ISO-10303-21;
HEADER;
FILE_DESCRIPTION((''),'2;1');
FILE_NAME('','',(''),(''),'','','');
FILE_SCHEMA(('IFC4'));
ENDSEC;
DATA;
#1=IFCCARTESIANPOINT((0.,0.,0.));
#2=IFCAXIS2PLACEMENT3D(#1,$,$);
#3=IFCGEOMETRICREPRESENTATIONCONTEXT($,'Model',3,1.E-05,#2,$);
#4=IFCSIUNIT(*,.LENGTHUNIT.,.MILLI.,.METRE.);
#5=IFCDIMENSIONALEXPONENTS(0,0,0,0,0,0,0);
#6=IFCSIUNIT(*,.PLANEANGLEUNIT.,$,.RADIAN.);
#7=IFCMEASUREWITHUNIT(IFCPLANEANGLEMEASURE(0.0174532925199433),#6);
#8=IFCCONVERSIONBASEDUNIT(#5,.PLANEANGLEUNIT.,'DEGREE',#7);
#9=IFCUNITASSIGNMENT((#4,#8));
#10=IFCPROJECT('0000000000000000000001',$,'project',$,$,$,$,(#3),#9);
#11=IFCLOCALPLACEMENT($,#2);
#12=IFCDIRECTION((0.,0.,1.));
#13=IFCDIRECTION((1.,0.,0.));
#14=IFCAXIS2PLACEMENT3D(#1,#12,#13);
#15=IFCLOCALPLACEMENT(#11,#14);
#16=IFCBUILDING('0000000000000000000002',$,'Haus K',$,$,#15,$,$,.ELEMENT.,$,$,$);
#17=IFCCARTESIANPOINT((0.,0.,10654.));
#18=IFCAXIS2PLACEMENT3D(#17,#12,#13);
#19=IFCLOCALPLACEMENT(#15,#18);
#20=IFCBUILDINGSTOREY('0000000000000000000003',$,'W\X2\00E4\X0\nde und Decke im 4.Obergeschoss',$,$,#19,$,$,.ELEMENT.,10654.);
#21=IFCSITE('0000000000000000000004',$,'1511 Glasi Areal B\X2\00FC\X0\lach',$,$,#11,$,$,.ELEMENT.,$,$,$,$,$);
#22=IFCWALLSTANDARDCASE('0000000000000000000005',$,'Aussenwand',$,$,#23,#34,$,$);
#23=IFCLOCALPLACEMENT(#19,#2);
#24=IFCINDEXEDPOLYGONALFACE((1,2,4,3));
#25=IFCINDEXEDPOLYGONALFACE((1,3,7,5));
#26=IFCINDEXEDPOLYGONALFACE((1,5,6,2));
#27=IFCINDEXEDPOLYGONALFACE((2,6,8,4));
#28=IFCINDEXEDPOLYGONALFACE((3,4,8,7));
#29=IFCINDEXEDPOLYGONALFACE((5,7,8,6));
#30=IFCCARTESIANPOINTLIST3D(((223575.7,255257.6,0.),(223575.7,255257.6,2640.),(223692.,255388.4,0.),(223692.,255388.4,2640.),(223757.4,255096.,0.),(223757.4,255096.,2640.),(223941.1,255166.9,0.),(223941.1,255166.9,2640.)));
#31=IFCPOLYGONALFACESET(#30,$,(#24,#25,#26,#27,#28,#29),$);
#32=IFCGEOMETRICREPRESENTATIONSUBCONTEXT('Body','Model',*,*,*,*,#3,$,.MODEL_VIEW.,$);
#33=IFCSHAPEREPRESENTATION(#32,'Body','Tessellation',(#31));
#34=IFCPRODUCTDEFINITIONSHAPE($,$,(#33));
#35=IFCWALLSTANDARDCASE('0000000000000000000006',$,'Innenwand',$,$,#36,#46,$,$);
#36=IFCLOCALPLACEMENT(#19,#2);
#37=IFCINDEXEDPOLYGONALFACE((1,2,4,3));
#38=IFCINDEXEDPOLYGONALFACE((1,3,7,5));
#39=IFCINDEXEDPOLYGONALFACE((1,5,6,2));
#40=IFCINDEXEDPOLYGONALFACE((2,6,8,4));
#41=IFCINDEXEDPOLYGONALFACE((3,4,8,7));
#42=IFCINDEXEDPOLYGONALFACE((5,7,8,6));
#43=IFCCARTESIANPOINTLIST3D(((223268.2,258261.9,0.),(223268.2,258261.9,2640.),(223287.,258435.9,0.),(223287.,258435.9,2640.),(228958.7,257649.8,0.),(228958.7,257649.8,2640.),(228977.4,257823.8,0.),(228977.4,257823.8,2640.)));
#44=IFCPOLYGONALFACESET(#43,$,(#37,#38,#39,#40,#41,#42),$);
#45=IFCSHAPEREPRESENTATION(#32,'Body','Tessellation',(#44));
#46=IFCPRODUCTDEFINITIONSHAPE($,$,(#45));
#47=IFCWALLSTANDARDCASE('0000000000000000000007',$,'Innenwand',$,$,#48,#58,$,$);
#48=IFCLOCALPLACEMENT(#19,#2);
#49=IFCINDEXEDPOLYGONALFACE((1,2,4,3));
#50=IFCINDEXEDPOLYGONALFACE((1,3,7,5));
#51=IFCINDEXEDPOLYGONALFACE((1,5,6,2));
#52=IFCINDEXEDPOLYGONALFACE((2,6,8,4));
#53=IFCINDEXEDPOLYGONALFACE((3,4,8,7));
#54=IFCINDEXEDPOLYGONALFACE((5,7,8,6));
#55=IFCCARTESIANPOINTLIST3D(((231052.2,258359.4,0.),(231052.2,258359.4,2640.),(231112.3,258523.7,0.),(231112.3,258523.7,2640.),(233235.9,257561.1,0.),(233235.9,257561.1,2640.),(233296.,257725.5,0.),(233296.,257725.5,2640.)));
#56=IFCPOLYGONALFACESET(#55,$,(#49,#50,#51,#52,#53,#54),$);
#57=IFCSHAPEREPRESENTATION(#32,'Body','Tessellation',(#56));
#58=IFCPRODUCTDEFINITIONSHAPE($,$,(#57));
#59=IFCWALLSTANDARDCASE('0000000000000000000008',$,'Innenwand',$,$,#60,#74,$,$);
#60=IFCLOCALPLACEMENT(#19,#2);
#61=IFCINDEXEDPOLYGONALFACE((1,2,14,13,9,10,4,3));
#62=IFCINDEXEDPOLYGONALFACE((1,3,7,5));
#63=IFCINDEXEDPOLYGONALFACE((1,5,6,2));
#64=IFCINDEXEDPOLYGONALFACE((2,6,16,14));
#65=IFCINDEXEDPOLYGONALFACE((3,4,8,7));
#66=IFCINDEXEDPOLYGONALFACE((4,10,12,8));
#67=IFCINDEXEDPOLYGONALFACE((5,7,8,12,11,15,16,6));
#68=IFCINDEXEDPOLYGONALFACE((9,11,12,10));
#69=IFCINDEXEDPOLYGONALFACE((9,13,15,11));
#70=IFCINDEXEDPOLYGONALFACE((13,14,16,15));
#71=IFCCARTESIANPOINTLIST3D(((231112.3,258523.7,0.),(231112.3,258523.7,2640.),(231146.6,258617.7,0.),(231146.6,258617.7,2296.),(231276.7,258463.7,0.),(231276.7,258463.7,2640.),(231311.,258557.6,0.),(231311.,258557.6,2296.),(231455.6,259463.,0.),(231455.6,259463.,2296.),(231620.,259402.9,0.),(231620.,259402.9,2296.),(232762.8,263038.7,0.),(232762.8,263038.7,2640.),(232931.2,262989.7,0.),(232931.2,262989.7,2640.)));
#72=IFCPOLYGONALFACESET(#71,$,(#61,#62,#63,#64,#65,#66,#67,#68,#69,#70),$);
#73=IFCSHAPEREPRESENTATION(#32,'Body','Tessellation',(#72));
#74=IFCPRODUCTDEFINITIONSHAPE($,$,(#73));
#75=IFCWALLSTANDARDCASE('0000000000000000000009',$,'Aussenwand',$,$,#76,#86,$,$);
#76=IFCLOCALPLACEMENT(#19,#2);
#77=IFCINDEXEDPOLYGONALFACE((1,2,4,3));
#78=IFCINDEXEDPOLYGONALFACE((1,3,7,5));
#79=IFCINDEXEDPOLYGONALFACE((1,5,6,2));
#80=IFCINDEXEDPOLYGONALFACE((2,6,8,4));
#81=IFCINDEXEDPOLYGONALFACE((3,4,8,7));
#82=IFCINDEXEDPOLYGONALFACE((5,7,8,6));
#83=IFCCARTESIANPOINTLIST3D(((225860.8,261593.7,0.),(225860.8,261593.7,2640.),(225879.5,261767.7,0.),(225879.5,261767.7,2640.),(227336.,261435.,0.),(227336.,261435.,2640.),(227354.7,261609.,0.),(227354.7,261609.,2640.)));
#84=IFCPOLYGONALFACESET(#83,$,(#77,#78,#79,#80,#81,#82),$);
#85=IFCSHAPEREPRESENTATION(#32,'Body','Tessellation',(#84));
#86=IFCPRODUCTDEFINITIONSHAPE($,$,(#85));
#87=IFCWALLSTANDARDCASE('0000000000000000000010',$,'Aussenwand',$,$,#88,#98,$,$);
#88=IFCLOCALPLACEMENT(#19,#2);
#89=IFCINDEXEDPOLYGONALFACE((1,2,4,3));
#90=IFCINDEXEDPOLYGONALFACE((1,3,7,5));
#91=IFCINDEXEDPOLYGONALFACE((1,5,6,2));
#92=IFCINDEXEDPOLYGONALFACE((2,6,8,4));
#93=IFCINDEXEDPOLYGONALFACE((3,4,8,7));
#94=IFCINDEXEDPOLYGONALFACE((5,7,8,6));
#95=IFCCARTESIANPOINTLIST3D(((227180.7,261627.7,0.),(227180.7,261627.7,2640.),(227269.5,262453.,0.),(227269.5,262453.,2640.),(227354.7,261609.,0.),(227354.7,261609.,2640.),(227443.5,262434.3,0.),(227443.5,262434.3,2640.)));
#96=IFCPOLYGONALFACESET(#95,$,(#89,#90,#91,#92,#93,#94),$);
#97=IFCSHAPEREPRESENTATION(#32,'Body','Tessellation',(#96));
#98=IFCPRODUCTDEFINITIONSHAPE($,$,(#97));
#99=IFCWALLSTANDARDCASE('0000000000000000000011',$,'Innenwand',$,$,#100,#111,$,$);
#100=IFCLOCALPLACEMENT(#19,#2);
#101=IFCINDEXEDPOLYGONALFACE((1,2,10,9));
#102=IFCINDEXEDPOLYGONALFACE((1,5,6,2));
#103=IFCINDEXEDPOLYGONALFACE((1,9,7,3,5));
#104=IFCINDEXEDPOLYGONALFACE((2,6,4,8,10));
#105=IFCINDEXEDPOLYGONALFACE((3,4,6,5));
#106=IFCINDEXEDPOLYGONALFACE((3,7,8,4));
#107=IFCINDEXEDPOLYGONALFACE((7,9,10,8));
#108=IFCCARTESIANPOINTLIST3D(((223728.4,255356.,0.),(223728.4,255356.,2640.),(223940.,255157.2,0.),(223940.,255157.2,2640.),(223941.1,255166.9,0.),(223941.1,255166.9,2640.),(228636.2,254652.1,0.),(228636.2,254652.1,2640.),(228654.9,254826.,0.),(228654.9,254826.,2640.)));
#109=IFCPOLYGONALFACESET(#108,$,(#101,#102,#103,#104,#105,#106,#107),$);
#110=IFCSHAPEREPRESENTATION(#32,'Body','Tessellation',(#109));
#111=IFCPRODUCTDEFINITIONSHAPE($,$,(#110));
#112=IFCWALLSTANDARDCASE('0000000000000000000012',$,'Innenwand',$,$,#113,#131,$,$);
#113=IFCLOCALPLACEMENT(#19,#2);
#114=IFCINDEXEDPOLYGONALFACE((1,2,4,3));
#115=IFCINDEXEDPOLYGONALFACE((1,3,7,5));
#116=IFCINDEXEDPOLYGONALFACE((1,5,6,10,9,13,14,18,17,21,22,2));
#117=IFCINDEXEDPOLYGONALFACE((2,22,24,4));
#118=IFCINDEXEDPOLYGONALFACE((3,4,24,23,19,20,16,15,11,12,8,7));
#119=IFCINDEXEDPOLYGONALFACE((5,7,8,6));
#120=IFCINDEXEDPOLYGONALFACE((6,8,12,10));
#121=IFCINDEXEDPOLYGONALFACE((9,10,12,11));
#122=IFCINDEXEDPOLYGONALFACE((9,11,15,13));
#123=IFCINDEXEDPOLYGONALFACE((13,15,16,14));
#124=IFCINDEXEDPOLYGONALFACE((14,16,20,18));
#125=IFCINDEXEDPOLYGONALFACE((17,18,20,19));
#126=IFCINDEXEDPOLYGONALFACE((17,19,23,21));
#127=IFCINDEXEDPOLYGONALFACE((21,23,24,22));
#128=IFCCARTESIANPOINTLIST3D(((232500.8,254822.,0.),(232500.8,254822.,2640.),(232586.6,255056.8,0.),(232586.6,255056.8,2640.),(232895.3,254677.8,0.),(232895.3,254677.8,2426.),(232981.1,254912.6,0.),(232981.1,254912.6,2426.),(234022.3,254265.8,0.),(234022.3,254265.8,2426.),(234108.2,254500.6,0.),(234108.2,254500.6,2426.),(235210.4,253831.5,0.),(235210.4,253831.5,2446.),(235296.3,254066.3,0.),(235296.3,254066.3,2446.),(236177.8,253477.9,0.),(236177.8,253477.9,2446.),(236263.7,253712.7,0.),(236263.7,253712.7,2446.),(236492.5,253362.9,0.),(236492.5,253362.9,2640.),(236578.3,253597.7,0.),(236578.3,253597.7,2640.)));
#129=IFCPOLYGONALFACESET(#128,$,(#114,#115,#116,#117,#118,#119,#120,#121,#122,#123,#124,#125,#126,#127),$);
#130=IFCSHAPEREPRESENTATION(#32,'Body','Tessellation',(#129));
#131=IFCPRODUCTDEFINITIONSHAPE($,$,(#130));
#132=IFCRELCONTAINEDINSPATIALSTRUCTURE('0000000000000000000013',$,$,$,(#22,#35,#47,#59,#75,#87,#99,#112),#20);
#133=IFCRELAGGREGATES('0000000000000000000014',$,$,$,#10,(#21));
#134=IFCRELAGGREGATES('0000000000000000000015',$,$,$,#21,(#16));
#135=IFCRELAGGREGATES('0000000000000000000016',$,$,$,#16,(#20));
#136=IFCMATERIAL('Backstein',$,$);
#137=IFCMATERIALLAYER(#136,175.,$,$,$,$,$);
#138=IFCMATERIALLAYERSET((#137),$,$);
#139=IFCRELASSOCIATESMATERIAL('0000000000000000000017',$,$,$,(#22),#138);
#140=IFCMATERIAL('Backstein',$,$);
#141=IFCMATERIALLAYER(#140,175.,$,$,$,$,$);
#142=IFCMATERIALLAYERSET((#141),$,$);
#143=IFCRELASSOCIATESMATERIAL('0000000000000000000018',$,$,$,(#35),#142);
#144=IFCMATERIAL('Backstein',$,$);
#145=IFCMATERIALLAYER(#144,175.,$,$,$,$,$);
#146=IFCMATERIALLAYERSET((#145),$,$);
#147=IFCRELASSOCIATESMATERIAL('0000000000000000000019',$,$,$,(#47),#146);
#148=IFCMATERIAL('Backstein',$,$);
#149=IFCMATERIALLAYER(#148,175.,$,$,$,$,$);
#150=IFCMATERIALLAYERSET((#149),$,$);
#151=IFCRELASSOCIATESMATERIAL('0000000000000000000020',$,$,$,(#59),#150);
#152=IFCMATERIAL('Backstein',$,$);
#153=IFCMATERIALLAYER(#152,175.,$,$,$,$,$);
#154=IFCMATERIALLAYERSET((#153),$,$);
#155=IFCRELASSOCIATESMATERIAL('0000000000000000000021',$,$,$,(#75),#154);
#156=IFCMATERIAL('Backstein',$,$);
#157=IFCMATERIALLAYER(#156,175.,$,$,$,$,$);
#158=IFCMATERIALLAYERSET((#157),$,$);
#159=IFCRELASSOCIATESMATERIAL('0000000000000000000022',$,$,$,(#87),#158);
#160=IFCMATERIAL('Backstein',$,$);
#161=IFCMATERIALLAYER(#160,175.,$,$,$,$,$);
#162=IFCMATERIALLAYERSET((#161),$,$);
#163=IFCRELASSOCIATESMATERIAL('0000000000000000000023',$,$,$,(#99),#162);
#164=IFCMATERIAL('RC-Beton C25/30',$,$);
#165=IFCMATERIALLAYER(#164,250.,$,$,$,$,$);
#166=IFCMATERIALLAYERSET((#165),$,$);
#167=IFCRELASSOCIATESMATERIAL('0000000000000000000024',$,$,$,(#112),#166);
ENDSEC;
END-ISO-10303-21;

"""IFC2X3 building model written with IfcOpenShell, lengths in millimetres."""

from ifc_helpers import new_model, entity, si_unit, converted_unit, frame, frame_2d, origin, origin_with_axes, place, context, subcontext, project, spatial, polyline, rectangle, outline, extrude, material, layer, layer_set, layer_usage, element, save


model = new_model("IFC2X3")

# Units and contexts
model_context = context("Model", 3, precision=1e-05, world=origin())
body_context = subcontext(model_context, "Body", "Model", "MODEL_VIEW")
ifc_project = project(units=[si_unit("LENGTHUNIT", "METRE", prefix="MILLI"), converted_unit("PLANEANGLEUNIT", "DEGREE", entity("IfcPlaneAngleMeasure", 0.0174532925199433), si_unit("PLANEANGLEUNIT", "RADIAN"), dimensions=[0, 0, 0, 0, 0, 0, 0])], contexts=[model_context])

# Site, building, storey
site_placement = place(None, origin())
site = spatial("IfcSite", under=ifc_project, at=site_placement, Name="1511 Glasi Areal Bülach", CompositionType="ELEMENT")
building_placement = place(site_placement, origin_with_axes())
building = spatial("IfcBuilding", under=site, at=building_placement, Name="Haus K", CompositionType="ELEMENT")
storey_placement = place(building_placement, frame((0.0, 0.0, 10654.0), z_axis=(0.0, 0.0, 1.0), x_axis=(1.0, 0.0, 0.0)))
storey = spatial("IfcBuildingStorey", under=building, at=storey_placement, Name="Wände und Decke im 4.Obergeschoss", CompositionType="ELEMENT", Elevation=10654.0)

# Walls
ifc_material_1 = material(Name="Backstein")
ifc_layer_1 = layer(ifc_material_1, 175.0)
ifc_layer_set_1 = layer_set([ifc_layer_1])
ifc_layer_usage_1 = layer_usage(ifc_layer_set_1, "AXIS2", "POSITIVE", 0.0)
wall_1_placement = place(storey_placement, frame((223575.7, 255257.6, 0.0), z_axis=(0.0, 0.0, 1.0), x_axis=(0.747334, -0.664448, 0.0)))
element("IfcWallStandardCase", 1, at=wall_1_placement, inside=storey, material=ifc_layer_usage_1, Name="Aussenwand", context=body_context, shape_type="SweptSolid", body=[
    extrude(outline(polyline([(0.0, 0.0), (243.1, 0.0), (333.3, 175.0), (0.0, 175.0), (0.0, 0.0)])), origin_with_axes(), (0.0, 0.0, 1.0), 2640.0),
])
ifc_material_2 = material(Name="Backstein")
ifc_layer_2 = layer(ifc_material_2, 175.0)
ifc_layer_set_2 = layer_set([ifc_layer_2])
ifc_layer_usage_2 = layer_usage(ifc_layer_set_2, "AXIS2", "POSITIVE", 0.0)
wall_2_placement = place(storey_placement, frame((223268.2, 258261.9, 0.0), z_axis=(0.0, 0.0, 1.0), x_axis=(0.994264, -0.106958, 0.0)))
element("IfcWallStandardCase", 2, at=wall_2_placement, inside=storey, material=ifc_layer_usage_2, Name="Innenwand", context=body_context, shape_type="SweptSolid", body=[
    extrude(rectangle(XDim=5723.3, YDim=175.0, at=frame_2d((2861.6, 87.5), x_axis=(1.0, 0.0))), origin_with_axes(), (0.0, 0.0, 1.0), 2640.0),
])
ifc_material_3 = material(Name="Backstein")
ifc_layer_3 = layer(ifc_material_3, 175.0)
ifc_layer_set_3 = layer_set([ifc_layer_3])
ifc_layer_usage_3 = layer_usage(ifc_layer_set_3, "AXIS2", "POSITIVE", 0.0)
wall_3_placement = place(storey_placement, frame((233296.0, 257725.5, 0.0), z_axis=(0.0, 0.0, 1.0), x_axis=(-0.939214, 0.343332, 0.0)))
element("IfcWallStandardCase", 3, at=wall_3_placement, inside=storey, material=ifc_layer_usage_3, Name="Innenwand", context=body_context, shape_type="SweptSolid", body=[
    extrude(rectangle(XDim=2325.0, YDim=175.0, at=frame_2d((1162.5, 87.5), x_axis=(1.0, 0.0))), origin_with_axes(), (0.0, 0.0, 1.0), 2640.0),
])

# Wall, opening
ifc_material_4 = material(Name="Backstein")
ifc_layer_4 = layer(ifc_material_4, 175.0)
ifc_layer_set_4 = layer_set([ifc_layer_4])
ifc_layer_usage_4 = layer_usage(ifc_layer_set_4, "AXIS2", "POSITIVE", 0.0)
wall_4_placement = place(storey_placement, frame((231276.7, 258463.7, 0.0), z_axis=(0.0, 0.0, 1.0), x_axis=(0.343332, 0.939214, 0.0)))
wall_4 = element("IfcWallStandardCase", 4, at=wall_4_placement, inside=storey, material=ifc_layer_usage_4, Name="Innenwand", context=body_context, shape_type="SweptSolid", body=[
    extrude(outline(polyline([(0.0, 0.0), (4818.9, 0.0), (4807.2, 175.0), (0.0, 175.0), (0.0, 0.0)])), origin_with_axes(), (0.0, 0.0, 1.0), 2640.0),
])
opening_1_placement = place(wall_4_placement, frame((100.0, 0.0, 0.0), z_axis=(0.0, 1.0, 0.0), x_axis=(0.0, 0.0, 1.0)))
element("IfcOpeningElement", 5, at=opening_1_placement, cuts=wall_4, ObjectType="Opening", context=body_context, shape_type="SweptSolid", body=[
    extrude(rectangle(XDim=2296.0, YDim=900.0, at=frame_2d((1148.0, 450.0), x_axis=(1.0, 0.0))), origin_with_axes(), (0.0, 0.0, 1.0), 175.0),
])

# Walls
ifc_material_5 = material(Name="Backstein")
ifc_layer_5 = layer(ifc_material_5, 175.0)
ifc_layer_set_5 = layer_set([ifc_layer_5])
ifc_layer_usage_5 = layer_usage(ifc_layer_set_5, "AXIS2", "POSITIVE", 0.0)
wall_5_placement = place(storey_placement, frame((227354.7, 261609.0, 0.0), z_axis=(0.0, 0.0, 1.0), x_axis=(-0.994264, 0.106958, 0.0)))
element("IfcWallStandardCase", 6, at=wall_5_placement, inside=storey, material=ifc_layer_usage_5, Name="Aussenwand", context=body_context, shape_type="SweptSolid", body=[
    extrude(rectangle(XDim=1483.7, YDim=175.0, at=frame_2d((741.9, 87.5), x_axis=(1.0, 0.0))), origin_with_axes(), (0.0, 0.0, 1.0), 2640.0),
])
ifc_material_6 = material(Name="Backstein")
ifc_layer_6 = layer(ifc_material_6, 175.0)
ifc_layer_set_6 = layer_set([ifc_layer_6])
ifc_layer_usage_6 = layer_usage(ifc_layer_set_6, "AXIS2", "POSITIVE", 0.0)
wall_6_placement = place(storey_placement, frame((227269.5, 262453.0, 0.0), z_axis=(0.0, 0.0, 1.0), x_axis=(-0.106958, -0.994264, 0.0)))
element("IfcWallStandardCase", 7, at=wall_6_placement, inside=storey, material=ifc_layer_usage_6, Name="Aussenwand", context=body_context, shape_type="SweptSolid", body=[
    extrude(rectangle(XDim=830.0, YDim=175.0, at=frame_2d((415.0, 87.5), x_axis=(1.0, 0.0))), origin_with_axes(), (0.0, 0.0, 1.0), 2640.0),
])
ifc_material_7 = material(Name="Backstein")
ifc_layer_7 = layer(ifc_material_7, 175.0)
ifc_layer_set_7 = layer_set([ifc_layer_7])
ifc_layer_usage_7 = layer_usage(ifc_layer_set_7, "AXIS2", "POSITIVE", 0.0)
wall_7_placement = place(storey_placement, frame((228654.9, 254826.0, 0.0), z_axis=(0.0, 0.0, 1.0), x_axis=(-0.994264, 0.106958, 0.0)))
element("IfcWallStandardCase", 8, at=wall_7_placement, inside=storey, material=ifc_layer_usage_7, Name="Innenwand", context=body_context, shape_type="SweptSolid", body=[
    extrude(outline(polyline([(0.0, 0.0), (4954.9, 0.0), (4723.3, 165.2), (4723.3, 175.0), (0.0, 175.0), (0.0, 0.0)])), origin_with_axes(), (0.0, 0.0, 1.0), 2640.0),
])

# Wall, openings
ifc_material_8 = material(Name="RC-Beton C25/30")
ifc_layer_8 = layer(ifc_material_8, 250.0)
ifc_layer_set_8 = layer_set([ifc_layer_8])
ifc_layer_usage_8 = layer_usage(ifc_layer_set_8, "AXIS2", "POSITIVE", 0.0)
wall_8_placement = place(storey_placement, frame((232500.8, 254822.0, 0.0), z_axis=(0.0, 0.0, 1.0), x_axis=(0.939214, -0.343332, 0.0)))
wall_8 = element("IfcWallStandardCase", 9, at=wall_8_placement, inside=storey, material=ifc_layer_usage_8, Name="Innenwand", context=body_context, shape_type="SweptSolid", body=[
    extrude(rectangle(XDim=4250.0, YDim=250.0, at=frame_2d((2125.0, 125.0), x_axis=(1.0, 0.0))), origin_with_axes(), (0.0, 0.0, 1.0), 2640.0),
])
opening_2_placement = place(wall_8_placement, frame((2885.0, 0.0, 0.0), z_axis=(0.0, 1.0, 0.0), x_axis=(0.0, 0.0, 1.0)))
element("IfcOpeningElement", 10, at=opening_2_placement, cuts=wall_8, ObjectType="Opening", context=body_context, shape_type="SweptSolid", body=[
    extrude(rectangle(XDim=2446.0, YDim=1030.0, at=frame_2d((1223.0, 515.0), x_axis=(1.0, 0.0))), origin_with_axes(), (0.0, 0.0, 1.0), 250.0),
])
opening_3_placement = place(wall_8_placement, frame((420.0, 0.0, 0.0), z_axis=(0.0, 1.0, 0.0), x_axis=(0.0, 0.0, 1.0)))
element("IfcOpeningElement", 11, at=opening_3_placement, cuts=wall_8, ObjectType="Opening", context=body_context, shape_type="SweptSolid", body=[
    extrude(rectangle(XDim=2426.0, YDim=1200.0, at=frame_2d((1213.0, 600.0), x_axis=(1.0, 0.0))), origin_with_axes(), (0.0, 0.0, 1.0), 250.0),
])

save(model, "model.ifc")
